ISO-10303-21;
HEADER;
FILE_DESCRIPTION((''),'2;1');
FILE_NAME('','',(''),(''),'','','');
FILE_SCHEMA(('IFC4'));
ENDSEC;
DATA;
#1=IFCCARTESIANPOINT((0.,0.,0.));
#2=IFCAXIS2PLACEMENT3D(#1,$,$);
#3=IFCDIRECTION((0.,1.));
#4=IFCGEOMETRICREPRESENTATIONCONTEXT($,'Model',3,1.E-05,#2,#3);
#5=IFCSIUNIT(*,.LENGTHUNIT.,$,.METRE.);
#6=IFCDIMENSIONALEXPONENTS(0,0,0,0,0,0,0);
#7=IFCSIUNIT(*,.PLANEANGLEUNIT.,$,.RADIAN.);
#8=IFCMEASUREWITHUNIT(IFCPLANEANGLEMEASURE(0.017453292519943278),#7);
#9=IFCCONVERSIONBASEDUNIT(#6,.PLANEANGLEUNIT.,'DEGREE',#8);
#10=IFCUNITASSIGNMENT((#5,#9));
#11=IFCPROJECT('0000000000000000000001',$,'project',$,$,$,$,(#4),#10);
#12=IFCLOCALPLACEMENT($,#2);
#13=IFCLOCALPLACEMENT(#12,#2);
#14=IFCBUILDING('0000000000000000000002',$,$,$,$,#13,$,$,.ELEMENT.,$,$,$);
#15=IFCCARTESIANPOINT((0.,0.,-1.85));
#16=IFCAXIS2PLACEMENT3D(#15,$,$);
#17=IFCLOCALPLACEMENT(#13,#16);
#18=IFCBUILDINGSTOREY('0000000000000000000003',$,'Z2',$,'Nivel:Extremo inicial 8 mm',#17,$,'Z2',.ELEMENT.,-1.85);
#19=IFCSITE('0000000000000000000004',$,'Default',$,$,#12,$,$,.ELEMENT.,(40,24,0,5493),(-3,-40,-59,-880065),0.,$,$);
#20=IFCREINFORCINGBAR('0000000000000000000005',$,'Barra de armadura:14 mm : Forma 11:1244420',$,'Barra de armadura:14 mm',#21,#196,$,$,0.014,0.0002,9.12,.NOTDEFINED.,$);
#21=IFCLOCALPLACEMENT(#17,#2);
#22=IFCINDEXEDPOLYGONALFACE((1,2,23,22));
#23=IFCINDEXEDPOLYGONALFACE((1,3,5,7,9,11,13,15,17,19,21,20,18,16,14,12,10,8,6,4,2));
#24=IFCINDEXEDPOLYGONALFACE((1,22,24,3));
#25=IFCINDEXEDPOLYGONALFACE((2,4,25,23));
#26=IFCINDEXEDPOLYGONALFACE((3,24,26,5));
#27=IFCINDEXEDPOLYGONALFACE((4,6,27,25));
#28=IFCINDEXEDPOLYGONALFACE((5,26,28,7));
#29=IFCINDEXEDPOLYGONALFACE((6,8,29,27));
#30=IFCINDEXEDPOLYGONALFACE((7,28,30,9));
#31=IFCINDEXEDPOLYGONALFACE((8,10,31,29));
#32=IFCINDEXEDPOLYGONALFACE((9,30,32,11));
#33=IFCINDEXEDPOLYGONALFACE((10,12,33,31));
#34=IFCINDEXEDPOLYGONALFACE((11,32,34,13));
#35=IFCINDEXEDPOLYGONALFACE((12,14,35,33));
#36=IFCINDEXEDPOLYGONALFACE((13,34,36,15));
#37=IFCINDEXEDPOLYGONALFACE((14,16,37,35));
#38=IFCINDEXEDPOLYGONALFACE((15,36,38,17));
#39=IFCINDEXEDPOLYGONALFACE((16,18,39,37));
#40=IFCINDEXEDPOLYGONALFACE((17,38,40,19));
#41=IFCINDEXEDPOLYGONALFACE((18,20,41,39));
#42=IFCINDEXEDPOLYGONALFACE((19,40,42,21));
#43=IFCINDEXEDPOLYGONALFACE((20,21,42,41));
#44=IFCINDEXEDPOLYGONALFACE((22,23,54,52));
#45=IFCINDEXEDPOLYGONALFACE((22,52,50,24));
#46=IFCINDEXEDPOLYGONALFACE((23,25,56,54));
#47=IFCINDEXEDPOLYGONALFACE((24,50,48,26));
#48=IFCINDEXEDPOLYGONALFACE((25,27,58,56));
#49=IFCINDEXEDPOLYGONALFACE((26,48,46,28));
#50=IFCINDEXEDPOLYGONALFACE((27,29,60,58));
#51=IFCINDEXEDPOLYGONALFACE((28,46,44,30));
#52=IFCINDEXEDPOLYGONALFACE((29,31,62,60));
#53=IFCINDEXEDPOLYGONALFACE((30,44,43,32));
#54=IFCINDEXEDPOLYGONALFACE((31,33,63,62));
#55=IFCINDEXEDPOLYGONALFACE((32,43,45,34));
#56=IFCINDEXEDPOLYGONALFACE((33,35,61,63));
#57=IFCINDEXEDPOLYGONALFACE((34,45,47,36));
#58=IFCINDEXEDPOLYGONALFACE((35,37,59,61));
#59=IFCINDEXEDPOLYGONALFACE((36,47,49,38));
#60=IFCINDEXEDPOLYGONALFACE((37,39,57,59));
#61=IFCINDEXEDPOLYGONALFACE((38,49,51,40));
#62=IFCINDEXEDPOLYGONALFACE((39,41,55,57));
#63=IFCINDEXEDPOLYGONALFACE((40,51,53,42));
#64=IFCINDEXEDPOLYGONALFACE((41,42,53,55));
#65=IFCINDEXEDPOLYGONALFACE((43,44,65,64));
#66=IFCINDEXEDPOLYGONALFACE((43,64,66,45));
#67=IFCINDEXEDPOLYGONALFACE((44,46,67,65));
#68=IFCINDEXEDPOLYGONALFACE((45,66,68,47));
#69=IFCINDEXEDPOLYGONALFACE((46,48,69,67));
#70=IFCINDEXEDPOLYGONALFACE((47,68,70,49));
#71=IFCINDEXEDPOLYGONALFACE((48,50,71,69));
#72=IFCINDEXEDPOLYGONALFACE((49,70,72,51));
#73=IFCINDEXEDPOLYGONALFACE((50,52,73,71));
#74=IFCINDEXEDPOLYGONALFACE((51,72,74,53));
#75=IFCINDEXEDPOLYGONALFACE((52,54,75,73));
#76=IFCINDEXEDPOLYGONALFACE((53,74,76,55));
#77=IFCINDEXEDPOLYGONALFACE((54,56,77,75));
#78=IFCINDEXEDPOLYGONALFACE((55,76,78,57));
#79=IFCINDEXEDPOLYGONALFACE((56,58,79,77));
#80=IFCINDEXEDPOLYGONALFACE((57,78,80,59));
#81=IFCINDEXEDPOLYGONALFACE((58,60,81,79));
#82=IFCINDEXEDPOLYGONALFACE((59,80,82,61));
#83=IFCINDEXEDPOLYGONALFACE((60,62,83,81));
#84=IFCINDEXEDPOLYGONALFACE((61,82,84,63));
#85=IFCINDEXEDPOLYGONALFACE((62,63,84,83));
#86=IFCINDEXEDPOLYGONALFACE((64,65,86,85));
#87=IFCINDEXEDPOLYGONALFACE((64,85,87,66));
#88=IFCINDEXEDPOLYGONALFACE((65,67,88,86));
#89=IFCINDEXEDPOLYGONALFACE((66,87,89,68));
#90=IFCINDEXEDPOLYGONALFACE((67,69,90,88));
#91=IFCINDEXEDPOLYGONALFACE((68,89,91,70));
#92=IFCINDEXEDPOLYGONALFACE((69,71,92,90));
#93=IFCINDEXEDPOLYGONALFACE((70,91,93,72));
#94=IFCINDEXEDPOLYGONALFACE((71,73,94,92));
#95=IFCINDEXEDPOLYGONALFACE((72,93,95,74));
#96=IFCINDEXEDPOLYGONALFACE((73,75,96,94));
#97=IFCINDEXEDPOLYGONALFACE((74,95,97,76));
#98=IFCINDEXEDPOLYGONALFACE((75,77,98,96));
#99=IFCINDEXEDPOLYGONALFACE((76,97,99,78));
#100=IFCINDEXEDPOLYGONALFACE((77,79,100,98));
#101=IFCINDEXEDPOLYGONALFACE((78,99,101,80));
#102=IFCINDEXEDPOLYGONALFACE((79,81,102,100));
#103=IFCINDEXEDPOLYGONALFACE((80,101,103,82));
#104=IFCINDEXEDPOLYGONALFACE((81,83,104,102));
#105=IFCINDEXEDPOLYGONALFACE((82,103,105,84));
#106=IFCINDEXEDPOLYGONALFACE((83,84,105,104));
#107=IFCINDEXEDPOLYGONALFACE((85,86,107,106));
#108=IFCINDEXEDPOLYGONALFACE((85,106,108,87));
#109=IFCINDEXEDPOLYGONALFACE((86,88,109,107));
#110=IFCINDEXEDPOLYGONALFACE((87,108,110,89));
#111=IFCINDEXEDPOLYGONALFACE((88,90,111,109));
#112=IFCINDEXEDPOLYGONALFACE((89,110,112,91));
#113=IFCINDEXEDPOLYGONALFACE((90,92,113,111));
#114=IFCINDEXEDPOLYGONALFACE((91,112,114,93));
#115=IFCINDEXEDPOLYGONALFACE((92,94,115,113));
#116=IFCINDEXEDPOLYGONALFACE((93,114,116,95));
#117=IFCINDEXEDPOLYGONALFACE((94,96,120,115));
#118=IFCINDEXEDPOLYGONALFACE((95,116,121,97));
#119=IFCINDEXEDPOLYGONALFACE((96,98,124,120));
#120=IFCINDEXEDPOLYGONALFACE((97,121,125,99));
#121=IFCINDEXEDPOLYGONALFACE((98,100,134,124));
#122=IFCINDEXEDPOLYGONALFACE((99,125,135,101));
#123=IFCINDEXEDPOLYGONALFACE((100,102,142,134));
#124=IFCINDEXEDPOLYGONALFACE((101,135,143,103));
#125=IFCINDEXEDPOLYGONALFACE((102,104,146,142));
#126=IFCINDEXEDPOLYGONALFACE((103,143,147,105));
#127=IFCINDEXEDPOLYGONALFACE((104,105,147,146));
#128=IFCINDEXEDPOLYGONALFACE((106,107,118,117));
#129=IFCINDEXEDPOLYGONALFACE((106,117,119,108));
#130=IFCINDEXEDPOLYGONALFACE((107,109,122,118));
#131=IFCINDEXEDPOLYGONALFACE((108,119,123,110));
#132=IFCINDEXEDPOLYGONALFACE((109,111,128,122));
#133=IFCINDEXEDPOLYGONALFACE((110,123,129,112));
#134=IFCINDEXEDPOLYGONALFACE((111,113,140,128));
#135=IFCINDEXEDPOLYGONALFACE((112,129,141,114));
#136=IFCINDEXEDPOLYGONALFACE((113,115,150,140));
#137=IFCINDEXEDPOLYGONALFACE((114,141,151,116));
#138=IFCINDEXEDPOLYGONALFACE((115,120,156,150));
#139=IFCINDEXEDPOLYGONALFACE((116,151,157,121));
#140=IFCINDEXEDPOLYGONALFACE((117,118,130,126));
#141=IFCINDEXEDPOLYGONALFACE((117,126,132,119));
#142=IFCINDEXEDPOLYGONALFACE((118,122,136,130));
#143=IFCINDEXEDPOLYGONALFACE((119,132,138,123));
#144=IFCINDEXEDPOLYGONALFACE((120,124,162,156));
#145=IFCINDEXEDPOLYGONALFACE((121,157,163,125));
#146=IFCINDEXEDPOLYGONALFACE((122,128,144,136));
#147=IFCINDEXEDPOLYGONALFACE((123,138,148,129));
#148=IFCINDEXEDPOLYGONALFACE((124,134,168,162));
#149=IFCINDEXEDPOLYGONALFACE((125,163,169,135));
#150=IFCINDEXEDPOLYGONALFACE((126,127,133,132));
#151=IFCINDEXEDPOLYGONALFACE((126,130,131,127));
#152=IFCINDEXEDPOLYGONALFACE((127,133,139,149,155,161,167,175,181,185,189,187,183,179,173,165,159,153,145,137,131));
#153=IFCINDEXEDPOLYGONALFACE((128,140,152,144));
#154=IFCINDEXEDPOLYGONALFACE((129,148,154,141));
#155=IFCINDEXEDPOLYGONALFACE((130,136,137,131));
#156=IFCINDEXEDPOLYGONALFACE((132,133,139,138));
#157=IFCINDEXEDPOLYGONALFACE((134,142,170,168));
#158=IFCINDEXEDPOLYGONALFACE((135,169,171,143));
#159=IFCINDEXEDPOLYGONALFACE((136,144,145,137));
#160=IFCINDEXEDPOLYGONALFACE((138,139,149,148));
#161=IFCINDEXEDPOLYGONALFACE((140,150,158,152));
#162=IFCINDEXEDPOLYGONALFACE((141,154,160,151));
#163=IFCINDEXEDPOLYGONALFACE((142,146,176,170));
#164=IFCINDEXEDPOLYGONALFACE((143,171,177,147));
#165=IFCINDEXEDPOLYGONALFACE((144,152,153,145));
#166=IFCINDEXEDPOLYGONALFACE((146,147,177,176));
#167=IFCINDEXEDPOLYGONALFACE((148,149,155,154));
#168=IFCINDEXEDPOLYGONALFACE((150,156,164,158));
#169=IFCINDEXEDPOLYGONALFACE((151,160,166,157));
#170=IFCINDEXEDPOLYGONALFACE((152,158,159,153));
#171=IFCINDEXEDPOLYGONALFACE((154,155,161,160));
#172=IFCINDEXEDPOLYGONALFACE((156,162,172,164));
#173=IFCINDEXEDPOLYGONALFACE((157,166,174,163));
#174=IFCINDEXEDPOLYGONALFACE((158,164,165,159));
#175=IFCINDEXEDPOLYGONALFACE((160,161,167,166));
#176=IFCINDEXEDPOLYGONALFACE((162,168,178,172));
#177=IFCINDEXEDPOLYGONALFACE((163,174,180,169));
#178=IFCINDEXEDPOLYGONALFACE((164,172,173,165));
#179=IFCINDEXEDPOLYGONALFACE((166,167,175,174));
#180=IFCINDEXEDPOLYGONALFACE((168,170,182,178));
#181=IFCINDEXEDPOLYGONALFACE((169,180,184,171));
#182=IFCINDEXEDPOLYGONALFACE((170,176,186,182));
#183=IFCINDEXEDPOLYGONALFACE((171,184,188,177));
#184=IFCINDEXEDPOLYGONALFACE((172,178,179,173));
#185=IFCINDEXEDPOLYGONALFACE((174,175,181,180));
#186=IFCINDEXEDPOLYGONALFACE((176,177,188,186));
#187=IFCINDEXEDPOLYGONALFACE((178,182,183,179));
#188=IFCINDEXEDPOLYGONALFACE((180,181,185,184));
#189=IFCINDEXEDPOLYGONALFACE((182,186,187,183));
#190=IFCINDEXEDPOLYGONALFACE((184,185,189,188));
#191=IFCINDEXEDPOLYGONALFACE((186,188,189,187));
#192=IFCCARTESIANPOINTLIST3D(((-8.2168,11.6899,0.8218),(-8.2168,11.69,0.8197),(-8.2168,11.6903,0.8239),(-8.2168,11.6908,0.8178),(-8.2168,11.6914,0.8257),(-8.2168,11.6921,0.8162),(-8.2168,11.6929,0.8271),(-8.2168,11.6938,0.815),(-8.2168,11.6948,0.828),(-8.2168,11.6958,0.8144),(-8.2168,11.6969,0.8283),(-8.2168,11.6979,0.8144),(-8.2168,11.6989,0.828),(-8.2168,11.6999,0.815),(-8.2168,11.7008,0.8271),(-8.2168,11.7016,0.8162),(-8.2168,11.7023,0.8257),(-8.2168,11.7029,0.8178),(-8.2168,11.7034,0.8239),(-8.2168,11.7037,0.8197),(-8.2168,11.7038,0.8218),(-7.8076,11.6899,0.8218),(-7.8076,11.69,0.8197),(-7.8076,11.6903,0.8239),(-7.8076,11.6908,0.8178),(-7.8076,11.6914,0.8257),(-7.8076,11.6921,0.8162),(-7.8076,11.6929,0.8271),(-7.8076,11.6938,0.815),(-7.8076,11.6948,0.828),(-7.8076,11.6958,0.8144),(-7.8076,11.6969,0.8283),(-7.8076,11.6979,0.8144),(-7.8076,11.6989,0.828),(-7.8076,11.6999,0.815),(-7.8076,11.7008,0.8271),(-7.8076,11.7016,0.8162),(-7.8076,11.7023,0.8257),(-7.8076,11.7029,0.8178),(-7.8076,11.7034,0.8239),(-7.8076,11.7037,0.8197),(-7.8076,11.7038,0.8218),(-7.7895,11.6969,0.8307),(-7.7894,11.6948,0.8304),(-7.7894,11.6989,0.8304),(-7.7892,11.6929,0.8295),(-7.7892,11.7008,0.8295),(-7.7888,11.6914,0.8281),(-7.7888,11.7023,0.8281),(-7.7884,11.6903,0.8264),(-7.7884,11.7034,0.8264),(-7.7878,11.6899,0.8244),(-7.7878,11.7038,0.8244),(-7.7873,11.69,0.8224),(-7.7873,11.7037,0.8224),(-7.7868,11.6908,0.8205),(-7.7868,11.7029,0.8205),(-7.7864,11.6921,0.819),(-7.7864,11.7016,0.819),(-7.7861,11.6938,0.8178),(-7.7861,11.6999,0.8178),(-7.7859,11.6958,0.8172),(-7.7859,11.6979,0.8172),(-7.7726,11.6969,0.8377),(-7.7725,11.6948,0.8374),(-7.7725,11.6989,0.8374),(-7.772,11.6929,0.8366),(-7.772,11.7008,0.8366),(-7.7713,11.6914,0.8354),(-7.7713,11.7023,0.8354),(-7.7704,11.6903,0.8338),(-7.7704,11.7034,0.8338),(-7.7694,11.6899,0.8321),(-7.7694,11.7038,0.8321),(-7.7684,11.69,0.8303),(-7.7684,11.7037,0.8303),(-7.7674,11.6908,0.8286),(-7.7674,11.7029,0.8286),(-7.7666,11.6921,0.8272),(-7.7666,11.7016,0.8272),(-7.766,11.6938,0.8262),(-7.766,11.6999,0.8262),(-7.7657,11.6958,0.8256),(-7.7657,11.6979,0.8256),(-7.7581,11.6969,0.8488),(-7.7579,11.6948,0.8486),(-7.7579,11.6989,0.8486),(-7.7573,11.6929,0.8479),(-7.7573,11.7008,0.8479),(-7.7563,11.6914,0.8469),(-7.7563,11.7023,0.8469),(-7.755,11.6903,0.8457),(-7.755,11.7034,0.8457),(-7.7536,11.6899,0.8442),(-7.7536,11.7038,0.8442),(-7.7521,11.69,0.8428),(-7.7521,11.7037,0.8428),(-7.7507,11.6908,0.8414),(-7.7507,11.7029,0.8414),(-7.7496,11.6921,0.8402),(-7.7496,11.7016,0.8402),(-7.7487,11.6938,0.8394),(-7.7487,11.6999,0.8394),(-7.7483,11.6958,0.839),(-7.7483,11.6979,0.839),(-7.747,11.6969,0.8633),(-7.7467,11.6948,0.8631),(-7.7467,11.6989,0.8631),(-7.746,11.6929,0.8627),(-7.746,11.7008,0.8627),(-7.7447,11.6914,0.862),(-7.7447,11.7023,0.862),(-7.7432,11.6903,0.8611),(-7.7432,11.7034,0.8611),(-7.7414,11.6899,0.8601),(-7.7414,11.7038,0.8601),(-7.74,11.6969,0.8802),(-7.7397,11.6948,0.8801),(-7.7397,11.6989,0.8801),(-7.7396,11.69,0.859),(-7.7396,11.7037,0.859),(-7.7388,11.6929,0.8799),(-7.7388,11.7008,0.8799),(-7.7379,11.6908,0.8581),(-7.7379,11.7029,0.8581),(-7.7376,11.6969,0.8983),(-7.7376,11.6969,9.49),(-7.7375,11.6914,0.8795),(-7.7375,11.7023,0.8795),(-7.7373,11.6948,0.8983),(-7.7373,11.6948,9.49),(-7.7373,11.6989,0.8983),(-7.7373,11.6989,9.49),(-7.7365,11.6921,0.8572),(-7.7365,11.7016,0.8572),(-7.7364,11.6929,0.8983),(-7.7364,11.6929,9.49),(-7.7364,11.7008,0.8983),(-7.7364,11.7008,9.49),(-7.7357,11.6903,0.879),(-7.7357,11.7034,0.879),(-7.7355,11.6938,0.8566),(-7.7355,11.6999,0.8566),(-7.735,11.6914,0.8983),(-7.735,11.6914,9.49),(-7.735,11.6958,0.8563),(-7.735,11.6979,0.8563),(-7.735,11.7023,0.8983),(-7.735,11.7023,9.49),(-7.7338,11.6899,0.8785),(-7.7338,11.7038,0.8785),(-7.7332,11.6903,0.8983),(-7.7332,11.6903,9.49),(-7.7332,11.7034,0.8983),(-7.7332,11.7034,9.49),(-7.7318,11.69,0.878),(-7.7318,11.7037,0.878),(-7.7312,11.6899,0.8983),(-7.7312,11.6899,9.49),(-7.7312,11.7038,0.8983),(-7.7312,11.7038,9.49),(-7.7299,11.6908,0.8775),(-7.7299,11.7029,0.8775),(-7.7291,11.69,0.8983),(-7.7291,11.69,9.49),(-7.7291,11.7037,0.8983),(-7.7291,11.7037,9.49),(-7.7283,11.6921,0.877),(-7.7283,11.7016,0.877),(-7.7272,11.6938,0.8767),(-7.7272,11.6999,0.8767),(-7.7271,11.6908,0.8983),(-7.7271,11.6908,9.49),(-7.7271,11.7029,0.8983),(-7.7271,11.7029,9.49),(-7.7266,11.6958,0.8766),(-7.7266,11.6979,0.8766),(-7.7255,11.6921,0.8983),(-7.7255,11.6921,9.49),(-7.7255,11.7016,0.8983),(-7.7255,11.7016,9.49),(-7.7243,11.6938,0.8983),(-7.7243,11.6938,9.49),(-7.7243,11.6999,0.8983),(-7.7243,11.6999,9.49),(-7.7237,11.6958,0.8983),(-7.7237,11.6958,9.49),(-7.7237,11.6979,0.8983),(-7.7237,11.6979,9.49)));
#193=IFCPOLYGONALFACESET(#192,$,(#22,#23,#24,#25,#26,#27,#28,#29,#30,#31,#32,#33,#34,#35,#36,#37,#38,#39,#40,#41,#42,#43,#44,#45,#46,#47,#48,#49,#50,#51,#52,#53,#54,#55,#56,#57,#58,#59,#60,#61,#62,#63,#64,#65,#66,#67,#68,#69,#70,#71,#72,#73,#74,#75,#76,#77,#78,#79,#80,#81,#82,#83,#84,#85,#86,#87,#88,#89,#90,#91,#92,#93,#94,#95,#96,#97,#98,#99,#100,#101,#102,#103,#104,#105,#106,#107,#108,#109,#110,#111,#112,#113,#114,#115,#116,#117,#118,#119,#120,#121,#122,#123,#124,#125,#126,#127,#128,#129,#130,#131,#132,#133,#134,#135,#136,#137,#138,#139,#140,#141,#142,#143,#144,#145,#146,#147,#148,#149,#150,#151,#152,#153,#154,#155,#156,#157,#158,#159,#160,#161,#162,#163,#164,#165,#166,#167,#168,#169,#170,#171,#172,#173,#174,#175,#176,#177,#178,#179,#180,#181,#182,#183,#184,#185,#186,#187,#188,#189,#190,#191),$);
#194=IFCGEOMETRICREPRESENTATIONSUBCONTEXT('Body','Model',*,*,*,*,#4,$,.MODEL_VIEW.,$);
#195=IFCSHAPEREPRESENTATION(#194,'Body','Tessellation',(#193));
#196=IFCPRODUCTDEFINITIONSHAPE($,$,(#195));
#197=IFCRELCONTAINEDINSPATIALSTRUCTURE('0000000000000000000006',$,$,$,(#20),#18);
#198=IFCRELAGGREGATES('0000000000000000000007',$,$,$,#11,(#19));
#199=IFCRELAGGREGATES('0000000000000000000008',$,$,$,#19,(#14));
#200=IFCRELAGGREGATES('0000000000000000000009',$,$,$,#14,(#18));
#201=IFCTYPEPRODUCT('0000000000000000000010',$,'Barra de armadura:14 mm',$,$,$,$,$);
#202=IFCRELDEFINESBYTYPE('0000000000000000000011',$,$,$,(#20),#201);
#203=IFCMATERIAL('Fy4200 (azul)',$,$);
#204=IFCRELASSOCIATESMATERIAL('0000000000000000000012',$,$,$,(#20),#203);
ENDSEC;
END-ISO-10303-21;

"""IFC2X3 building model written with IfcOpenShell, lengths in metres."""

from ifc_helpers import new_model, entity, si_unit, converted_unit, direction, frame, origin, place, context, subcontext, project, spatial, material, type_object, element, save


model = new_model("IFC2X3")

# Units and contexts
model_context = context("Model", 3, precision=1e-05, world=origin(), true_north=direction((0.0, 1.0)))
body_context = subcontext(model_context, "Body", "Model", "MODEL_VIEW")
ifc_project = project(units=[si_unit("LENGTHUNIT", "METRE"), converted_unit("PLANEANGLEUNIT", "DEGREE", entity("IfcPlaneAngleMeasure", 0.017453292519943278), si_unit("PLANEANGLEUNIT", "RADIAN"), dimensions=[0, 0, 0, 0, 0, 0, 0])], contexts=[model_context])

# Site, building, storey
site_placement = place(None, origin())
site = spatial("IfcSite", under=ifc_project, at=site_placement, Name="Default", CompositionType="ELEMENT", RefLatitude=(40, 24, 0, 5493), RefLongitude=(-3, -40, -59, -880065), RefElevation=0.0)
building_placement = place(site_placement, origin())
building = spatial("IfcBuilding", under=site, at=building_placement, CompositionType="ELEMENT")
storey_placement = place(building_placement, frame((0.0, 0.0, -1.85)))
storey = spatial("IfcBuildingStorey", under=building, at=storey_placement, Name="Z2", ObjectType="Nivel:Extremo inicial 8 mm", LongName="Z2", CompositionType="ELEMENT", Elevation=-1.85)

# Reinforcing bar
ifc_material_1 = material(Name="Fy4200 (azul)")
type_product_1 = type_object("IfcTypeProduct", Name="Barra de armadura:14 mm")
reinforcing_bar_1_placement = place(storey_placement, origin())
element("IfcReinforcingBar", 1, at=reinforcing_bar_1_placement, inside=storey, type_object=type_product_1, material=ifc_material_1, Name="Barra de armadura:14 mm : Forma 11:1244420", ObjectType="Barra de armadura:14 mm", BarLength=9.12, BarRole="NOTDEFINED", CrossSectionArea=0.0002, NominalDiameter=0.014, context=body_context, shape_type="AdvancedSweptSolid", body=[
    entity("IfcSweptDiskSolid", entity("IfcCompositeCurve", [entity("IfcCompositeCurveSegment", "CONTINUOUS", True, entity("IfcPolyline", [entity("IfcCartesianPoint", [-7.7306, 11.6969, 9.49]), entity("IfcCartesianPoint", [-7.7306, 11.6969, 0.8983])])), entity("IfcCompositeCurveSegment", "CONTINUOUS", True, entity("IfcTrimmedCurve", entity("IfcCircle", entity("IfcAxis2Placement3D", entity("IfcCartesianPoint", [-7.8076, 11.6969, 0.8983]), entity("IfcDirection", [0.0, 1.0, 0.0]), entity("IfcDirection", [0.0, 0.0, -1.0])), 0.077), [entity("IfcParameterValue", 270.0)], [entity("IfcParameterValue", 360.0)], True, "PARAMETER")), entity("IfcCompositeCurveSegment", "CONTINUOUS", True, entity("IfcPolyline", [entity("IfcCartesianPoint", [-7.8076, 11.6969, 0.8213]), entity("IfcCartesianPoint", [-8.2168, 11.6969, 0.8213])]))], False), 0.007, None, 0.0, 92.0),
])

save(model, "model.ifc")
